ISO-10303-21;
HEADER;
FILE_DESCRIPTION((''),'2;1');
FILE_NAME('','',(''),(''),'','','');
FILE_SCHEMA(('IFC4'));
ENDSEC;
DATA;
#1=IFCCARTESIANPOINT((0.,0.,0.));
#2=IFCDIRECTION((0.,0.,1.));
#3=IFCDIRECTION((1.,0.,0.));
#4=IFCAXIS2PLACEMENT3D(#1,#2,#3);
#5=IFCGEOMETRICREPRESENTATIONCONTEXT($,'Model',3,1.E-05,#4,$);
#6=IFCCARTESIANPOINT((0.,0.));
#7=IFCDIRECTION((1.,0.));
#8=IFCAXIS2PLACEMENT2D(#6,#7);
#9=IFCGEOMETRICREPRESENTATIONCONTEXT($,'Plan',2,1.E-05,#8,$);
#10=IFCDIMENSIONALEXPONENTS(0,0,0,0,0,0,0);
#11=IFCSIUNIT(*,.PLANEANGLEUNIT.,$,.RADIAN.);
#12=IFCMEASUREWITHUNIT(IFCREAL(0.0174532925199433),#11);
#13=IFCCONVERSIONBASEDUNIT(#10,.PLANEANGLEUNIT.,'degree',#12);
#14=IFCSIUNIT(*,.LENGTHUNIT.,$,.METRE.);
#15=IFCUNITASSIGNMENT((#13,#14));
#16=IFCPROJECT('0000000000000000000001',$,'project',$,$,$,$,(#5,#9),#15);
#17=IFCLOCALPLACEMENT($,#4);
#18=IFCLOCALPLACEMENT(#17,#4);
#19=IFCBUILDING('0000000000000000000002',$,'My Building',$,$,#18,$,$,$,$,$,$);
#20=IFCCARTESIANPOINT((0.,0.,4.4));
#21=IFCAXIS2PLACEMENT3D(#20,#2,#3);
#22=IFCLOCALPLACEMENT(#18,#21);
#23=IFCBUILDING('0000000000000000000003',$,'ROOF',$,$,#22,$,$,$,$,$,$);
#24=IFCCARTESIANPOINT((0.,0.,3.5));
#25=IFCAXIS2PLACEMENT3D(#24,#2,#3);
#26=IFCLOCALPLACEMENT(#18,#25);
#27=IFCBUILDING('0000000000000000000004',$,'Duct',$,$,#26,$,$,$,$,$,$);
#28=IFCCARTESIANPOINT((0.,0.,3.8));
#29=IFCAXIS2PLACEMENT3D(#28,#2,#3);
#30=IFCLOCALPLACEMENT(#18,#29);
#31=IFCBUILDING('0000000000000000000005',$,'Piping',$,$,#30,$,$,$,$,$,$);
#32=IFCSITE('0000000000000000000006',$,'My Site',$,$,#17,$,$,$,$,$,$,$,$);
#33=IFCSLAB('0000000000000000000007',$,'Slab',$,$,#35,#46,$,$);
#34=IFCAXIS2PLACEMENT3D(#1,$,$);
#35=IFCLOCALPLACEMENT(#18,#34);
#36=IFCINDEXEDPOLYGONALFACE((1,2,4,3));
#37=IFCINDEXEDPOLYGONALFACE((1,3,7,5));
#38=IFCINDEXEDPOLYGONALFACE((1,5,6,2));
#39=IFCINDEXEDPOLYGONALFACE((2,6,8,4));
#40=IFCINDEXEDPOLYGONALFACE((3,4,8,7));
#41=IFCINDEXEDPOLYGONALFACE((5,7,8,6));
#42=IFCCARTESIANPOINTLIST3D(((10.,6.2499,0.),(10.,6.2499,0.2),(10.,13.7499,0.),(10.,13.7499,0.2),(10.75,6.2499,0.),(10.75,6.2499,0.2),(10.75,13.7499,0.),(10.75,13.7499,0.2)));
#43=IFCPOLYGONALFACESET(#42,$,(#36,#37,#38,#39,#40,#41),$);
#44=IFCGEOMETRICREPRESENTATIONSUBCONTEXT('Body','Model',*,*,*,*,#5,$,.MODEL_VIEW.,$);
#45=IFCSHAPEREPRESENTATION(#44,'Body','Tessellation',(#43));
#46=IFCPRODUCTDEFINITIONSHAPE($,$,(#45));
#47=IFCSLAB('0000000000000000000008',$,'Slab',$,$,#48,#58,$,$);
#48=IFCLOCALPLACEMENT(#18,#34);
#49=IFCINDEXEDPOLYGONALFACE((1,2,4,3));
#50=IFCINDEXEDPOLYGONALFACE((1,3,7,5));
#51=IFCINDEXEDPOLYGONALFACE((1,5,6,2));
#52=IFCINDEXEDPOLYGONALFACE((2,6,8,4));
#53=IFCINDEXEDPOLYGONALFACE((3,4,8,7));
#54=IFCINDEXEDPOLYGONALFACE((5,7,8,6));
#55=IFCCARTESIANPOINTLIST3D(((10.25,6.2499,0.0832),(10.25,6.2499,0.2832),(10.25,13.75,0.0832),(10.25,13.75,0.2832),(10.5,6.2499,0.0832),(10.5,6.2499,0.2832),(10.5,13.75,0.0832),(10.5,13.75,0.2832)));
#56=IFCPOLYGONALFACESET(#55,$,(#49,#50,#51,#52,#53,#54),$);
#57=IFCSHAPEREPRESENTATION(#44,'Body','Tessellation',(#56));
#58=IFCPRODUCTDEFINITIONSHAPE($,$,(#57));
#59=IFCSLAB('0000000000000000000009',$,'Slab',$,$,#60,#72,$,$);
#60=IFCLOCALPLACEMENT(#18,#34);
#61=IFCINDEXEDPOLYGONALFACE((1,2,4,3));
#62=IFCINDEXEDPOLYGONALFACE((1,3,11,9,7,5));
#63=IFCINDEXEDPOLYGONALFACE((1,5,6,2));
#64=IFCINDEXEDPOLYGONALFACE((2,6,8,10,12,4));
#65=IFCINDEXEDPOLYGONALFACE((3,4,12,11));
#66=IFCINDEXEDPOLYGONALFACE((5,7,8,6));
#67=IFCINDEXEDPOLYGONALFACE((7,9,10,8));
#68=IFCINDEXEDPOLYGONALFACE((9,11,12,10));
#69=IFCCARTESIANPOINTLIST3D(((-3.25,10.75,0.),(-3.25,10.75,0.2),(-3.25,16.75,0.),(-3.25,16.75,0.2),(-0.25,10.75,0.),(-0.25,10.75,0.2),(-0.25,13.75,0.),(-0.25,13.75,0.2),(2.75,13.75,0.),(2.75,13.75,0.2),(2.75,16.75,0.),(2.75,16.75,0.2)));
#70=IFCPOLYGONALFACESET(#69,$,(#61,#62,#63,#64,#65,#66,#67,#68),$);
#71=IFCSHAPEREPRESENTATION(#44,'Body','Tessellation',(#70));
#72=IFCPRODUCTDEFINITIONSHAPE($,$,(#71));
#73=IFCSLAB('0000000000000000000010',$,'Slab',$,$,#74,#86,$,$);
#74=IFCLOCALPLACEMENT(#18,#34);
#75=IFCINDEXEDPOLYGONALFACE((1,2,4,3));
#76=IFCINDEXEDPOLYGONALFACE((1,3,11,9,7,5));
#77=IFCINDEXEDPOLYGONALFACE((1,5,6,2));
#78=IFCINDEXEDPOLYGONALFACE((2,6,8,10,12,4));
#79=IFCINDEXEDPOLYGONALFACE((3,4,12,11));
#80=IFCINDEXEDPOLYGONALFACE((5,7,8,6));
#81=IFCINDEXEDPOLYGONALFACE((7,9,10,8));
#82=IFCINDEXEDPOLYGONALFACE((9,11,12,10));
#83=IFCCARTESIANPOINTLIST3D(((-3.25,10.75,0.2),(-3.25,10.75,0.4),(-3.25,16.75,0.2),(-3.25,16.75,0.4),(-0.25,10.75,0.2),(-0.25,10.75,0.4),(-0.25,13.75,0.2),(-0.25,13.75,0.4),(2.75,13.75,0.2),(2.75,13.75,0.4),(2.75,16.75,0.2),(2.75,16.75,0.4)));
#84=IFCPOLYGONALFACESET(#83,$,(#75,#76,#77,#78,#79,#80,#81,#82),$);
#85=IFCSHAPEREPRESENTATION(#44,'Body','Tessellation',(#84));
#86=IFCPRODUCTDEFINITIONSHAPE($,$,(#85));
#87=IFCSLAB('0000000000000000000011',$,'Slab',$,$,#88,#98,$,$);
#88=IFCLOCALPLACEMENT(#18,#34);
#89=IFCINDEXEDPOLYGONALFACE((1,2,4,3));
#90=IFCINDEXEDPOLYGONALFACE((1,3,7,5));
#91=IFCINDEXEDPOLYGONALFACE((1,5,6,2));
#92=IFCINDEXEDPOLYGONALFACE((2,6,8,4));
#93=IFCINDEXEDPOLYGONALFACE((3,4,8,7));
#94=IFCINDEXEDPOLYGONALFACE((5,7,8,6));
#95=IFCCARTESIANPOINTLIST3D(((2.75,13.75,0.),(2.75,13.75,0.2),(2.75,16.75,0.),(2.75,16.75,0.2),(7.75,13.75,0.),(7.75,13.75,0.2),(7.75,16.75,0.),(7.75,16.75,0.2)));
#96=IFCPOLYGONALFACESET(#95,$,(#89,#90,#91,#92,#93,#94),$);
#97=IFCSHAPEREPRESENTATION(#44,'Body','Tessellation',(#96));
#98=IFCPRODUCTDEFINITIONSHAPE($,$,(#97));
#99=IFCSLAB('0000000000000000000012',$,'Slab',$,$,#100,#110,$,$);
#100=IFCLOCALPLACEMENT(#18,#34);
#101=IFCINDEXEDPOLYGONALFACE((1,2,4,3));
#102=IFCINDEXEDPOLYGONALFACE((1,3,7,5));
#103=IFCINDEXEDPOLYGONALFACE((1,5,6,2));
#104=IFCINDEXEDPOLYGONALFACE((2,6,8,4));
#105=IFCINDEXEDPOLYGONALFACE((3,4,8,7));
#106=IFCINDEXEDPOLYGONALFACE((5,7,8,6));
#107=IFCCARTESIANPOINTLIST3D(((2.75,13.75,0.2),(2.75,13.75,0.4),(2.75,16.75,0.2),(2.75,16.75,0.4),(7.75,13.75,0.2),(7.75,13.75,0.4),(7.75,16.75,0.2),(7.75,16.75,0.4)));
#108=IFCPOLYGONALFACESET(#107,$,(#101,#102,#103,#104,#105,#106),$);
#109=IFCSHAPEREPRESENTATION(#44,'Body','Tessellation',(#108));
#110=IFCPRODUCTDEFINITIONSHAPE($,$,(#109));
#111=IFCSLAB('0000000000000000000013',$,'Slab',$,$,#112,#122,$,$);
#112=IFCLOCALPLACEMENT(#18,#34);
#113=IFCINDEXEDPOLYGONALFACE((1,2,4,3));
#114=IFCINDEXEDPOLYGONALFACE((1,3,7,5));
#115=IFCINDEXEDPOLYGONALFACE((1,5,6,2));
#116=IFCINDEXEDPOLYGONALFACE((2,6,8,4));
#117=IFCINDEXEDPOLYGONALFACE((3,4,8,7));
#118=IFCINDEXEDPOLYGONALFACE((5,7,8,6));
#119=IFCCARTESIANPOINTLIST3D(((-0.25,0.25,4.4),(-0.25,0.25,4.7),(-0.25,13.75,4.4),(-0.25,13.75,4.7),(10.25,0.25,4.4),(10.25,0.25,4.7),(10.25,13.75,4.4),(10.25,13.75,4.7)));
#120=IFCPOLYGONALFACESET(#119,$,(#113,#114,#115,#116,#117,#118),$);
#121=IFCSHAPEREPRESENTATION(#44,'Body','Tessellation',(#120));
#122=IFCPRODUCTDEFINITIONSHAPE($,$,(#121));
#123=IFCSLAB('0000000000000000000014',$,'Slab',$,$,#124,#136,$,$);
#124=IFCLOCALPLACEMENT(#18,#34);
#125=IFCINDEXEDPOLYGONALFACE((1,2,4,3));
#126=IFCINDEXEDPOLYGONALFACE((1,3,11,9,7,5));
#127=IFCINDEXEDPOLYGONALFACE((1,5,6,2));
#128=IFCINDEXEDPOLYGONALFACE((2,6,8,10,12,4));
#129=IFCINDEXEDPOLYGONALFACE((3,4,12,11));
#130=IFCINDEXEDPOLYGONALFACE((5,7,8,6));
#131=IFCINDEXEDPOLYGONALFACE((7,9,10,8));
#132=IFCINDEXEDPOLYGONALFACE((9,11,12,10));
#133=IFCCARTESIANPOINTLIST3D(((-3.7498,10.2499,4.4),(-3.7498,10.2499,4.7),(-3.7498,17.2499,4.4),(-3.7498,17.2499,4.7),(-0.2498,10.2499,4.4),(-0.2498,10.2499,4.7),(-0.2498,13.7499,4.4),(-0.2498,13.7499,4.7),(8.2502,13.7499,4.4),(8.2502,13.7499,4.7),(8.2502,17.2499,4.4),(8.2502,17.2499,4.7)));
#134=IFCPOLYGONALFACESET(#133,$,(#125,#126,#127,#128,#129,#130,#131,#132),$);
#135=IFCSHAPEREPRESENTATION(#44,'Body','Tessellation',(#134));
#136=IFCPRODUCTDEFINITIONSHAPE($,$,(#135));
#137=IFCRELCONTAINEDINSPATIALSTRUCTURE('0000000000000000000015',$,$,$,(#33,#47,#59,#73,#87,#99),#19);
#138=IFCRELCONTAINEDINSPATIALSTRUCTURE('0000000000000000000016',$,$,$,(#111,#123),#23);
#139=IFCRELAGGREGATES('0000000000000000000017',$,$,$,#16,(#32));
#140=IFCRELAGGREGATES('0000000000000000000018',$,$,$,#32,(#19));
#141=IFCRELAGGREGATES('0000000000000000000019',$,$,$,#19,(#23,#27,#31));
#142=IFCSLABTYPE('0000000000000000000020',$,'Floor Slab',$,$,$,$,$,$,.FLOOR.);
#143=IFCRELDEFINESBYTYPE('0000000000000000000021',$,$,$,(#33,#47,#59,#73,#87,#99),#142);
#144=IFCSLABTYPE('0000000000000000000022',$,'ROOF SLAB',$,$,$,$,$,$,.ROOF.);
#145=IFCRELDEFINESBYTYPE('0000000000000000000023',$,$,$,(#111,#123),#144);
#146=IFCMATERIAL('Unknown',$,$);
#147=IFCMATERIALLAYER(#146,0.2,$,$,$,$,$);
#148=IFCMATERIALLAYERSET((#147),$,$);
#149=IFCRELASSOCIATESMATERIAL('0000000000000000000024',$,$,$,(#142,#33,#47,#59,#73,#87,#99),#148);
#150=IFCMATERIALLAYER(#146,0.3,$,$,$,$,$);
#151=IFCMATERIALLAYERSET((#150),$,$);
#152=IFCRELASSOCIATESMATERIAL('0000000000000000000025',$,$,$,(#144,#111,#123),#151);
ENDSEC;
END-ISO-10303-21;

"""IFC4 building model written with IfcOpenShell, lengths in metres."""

from ifc_helpers import new_model, entity, si_unit, converted_unit, frame, origin_with_axes, origin_2d_with_axis, place, context, subcontext, project, spatial, indexed_curve, outline, extrude, material, layer, layer_set, layer_usage, type_object, element, save


model = new_model("IFC4")

# Units and contexts
model_context = context("Model", 3, precision=1e-05, world=origin_with_axes())
plan_context = context("Plan", 2, precision=1e-05, world=origin_2d_with_axis())
body_context_1 = subcontext(model_context, "Body", "Model", "MODEL_VIEW")
ifc_project = project(units=[converted_unit("PLANEANGLEUNIT", "degree", entity("IfcReal", 0.0174532925199433), si_unit("PLANEANGLEUNIT", "RADIAN"), dimensions=[0, 0, 0, 0, 0, 0, 0]), si_unit("LENGTHUNIT", "METRE")], contexts=[model_context, plan_context])

# Site, building
site_placement = place(None, origin_with_axes())
site = spatial("IfcSite", under=ifc_project, at=site_placement, Name="My Site")
building_1_placement = place(site_placement, origin_with_axes())
building_1 = spatial("IfcBuilding", under=site, at=building_1_placement, Name="My Building")

# Slabs
ifc_material = material(Name="Unknown")
ifc_layer_1 = layer(ifc_material, 0.2)
ifc_layer_set_1 = layer_set([ifc_layer_1])
ifc_layer_usage_1 = layer_usage(ifc_layer_set_1, "AXIS3", "POSITIVE", 0.0)
slab_type_1 = type_object("IfcSlabType", Name="Floor Slab", PredefinedType="FLOOR", material=ifc_layer_set_1)
slab_1_placement = place(building_1_placement, frame((10.0, 13.7499, 0.0), z_axis=(0.0, 0.0, 1.0), x_axis=(1.0, 0.0, 0.0)))
element("IfcSlab", 1, at=slab_1_placement, inside=building_1, type_object=slab_type_1, material=ifc_layer_usage_1, Name="Slab", context=body_context_1, shape_type="SweptSolid", body=[
    extrude(outline(indexed_curve([(0.0, 0.0), (0.75, 0.0), (0.75, -7.5), (0.0, -7.5), (0.0, 0.0)])), None, (0.0, 0.0, 1.0), 0.2),
])
ifc_layer_usage_2 = layer_usage(ifc_layer_set_1, "AXIS3", "POSITIVE", 0.0)
slab_2_placement = place(building_1_placement, frame((10.25, 13.75, 0.0832), z_axis=(0.0, 0.0, 1.0), x_axis=(1.0, 0.0, 0.0)))
element("IfcSlab", 2, at=slab_2_placement, inside=building_1, type_object=slab_type_1, material=ifc_layer_usage_2, Name="Slab", context=body_context_1, shape_type="SweptSolid", body=[
    extrude(outline(indexed_curve([(0.0, 0.0), (0.25, 0.0), (0.25, -7.5001), (0.0, -7.5001), (0.0, 0.0)])), None, (0.0, 0.0, 1.0), 0.2),
])
ifc_layer_usage_3 = layer_usage(ifc_layer_set_1, "AXIS3", "POSITIVE", 0.0)
slab_3_placement = place(building_1_placement, frame((-0.25, 13.75, 0.0), z_axis=(0.0, 0.0, 1.0), x_axis=(1.0, 0.0, 0.0)))
element("IfcSlab", 3, at=slab_3_placement, inside=building_1, type_object=slab_type_1, material=ifc_layer_usage_3, Name="Slab", context=body_context_1, shape_type="SweptSolid", body=[
    extrude(outline(indexed_curve([(0.0, 0.0), (3.0, 0.0), (3.0, 3.0), (-3.0, 3.0), (-3.0, -3.0), (0.0, -3.0), (0.0, 0.0)])), None, (0.0, 0.0, 1.0), 0.2),
])
ifc_layer_usage_4 = layer_usage(ifc_layer_set_1, "AXIS3", "POSITIVE", 0.0)
slab_4_placement = place(building_1_placement, frame((-0.25, 13.75, 0.2), z_axis=(0.0, 0.0, 1.0), x_axis=(1.0, 0.0, 0.0)))
element("IfcSlab", 4, at=slab_4_placement, inside=building_1, type_object=slab_type_1, material=ifc_layer_usage_4, Name="Slab", context=body_context_1, shape_type="SweptSolid", body=[
    extrude(outline(indexed_curve([(0.0, 0.0), (3.0, 0.0), (3.0, 3.0), (-3.0, 3.0), (-3.0, -3.0), (0.0, -3.0), (0.0, 0.0)])), None, (0.0, 0.0, 1.0), 0.2),
])
ifc_layer_usage_5 = layer_usage(ifc_layer_set_1, "AXIS3", "POSITIVE", 0.0)
slab_5_placement = place(building_1_placement, frame((2.75, 16.75, 0.0), z_axis=(0.0, 0.0, 1.0), x_axis=(1.0, 0.0, 0.0)))
element("IfcSlab", 5, at=slab_5_placement, inside=building_1, type_object=slab_type_1, material=ifc_layer_usage_5, Name="Slab", context=body_context_1, shape_type="SweptSolid", body=[
    extrude(outline(indexed_curve([(0.0, 0.0), (5.0, 0.0), (5.0, -3.0), (0.0, -3.0), (0.0, 0.0)])), None, (0.0, 0.0, 1.0), 0.2),
])
ifc_layer_usage_6 = layer_usage(ifc_layer_set_1, "AXIS3", "POSITIVE", 0.0)
slab_6_placement = place(building_1_placement, frame((2.75, 16.75, 0.2), z_axis=(0.0, 0.0, 1.0), x_axis=(1.0, 0.0, 0.0)))
element("IfcSlab", 6, at=slab_6_placement, inside=building_1, type_object=slab_type_1, material=ifc_layer_usage_6, Name="Slab", context=body_context_1, shape_type="SweptSolid", body=[
    extrude(outline(indexed_curve([(0.0, 0.0), (5.0, 0.0), (5.0, -3.0), (0.0, -3.0), (0.0, 0.0)])), None, (0.0, 0.0, 1.0), 0.2),
])

# Shared definitions
building_2_placement = place(building_1_placement, frame((0.0, 0.0, 4.4), z_axis=(0.0, 0.0, 1.0), x_axis=(1.0, 0.0, 0.0)))
building_2 = spatial("IfcBuilding", under=building_1, at=building_2_placement, Name="ROOF")

# Slabs
ifc_layer_2 = layer(ifc_material, 0.3)
ifc_layer_set_2 = layer_set([ifc_layer_2])
ifc_layer_usage_7 = layer_usage(ifc_layer_set_2, "AXIS3", "POSITIVE", 0.0)
slab_type_2 = type_object("IfcSlabType", Name="ROOF SLAB", PredefinedType="ROOF", material=ifc_layer_set_2)
slab_7_placement = place(building_2_placement, frame((-0.25, 13.75, 0.0), z_axis=(0.0, 0.0, 1.0), x_axis=(1.0, 0.0, 0.0)))
element("IfcSlab", 7, at=slab_7_placement, inside=building_2, type_object=slab_type_2, material=ifc_layer_usage_7, Name="Slab", context=body_context_1, shape_type="SweptSolid", body=[
    extrude(outline(indexed_curve([(0.0, 0.0), (10.5, 0.0), (10.5, -13.5), (0.0, -13.5), (0.0, 0.0)])), None, (0.0, 0.0, 1.0), 0.3),
])
ifc_layer_usage_8 = layer_usage(ifc_layer_set_2, "AXIS3", "POSITIVE", -0.3)
slab_8_placement = place(building_2_placement, frame((-3.7498, 17.2499, 0.3), z_axis=(0.0, 0.0, 1.0), x_axis=(1.0, 0.0, 0.0)))
element("IfcSlab", 8, at=slab_8_placement, inside=building_2, type_object=slab_type_2, material=ifc_layer_usage_8, Name="Slab", context=body_context_1, shape_type="SweptSolid", body=[
    extrude(outline(indexed_curve([(0.0, 0.0), (12.0, 0.0), (12.0, -3.5), (3.5, -3.5), (3.5, -7.0), (0.0, -7.0), (0.0, 0.0)])), frame((0.0, 0.0, -0.3), z_axis=(0.0, 0.0, 1.0), x_axis=(1.0, 0.0, 0.0)), (0.0, 0.0, 1.0), 0.3),
])

# Shared definitions
building_3_placement = place(building_1_placement, frame((0.0, 0.0, 3.5), z_axis=(0.0, 0.0, 1.0), x_axis=(1.0, 0.0, 0.0)))
building_3 = spatial("IfcBuilding", under=building_1, at=building_3_placement, Name="Duct")

# Shared definitions
building_4_placement = place(building_1_placement, frame((0.0, 0.0, 3.8), z_axis=(0.0, 0.0, 1.0), x_axis=(1.0, 0.0, 0.0)))
building_4 = spatial("IfcBuilding", under=building_1, at=building_4_placement, Name="Piping")

save(model, "model.ifc")
